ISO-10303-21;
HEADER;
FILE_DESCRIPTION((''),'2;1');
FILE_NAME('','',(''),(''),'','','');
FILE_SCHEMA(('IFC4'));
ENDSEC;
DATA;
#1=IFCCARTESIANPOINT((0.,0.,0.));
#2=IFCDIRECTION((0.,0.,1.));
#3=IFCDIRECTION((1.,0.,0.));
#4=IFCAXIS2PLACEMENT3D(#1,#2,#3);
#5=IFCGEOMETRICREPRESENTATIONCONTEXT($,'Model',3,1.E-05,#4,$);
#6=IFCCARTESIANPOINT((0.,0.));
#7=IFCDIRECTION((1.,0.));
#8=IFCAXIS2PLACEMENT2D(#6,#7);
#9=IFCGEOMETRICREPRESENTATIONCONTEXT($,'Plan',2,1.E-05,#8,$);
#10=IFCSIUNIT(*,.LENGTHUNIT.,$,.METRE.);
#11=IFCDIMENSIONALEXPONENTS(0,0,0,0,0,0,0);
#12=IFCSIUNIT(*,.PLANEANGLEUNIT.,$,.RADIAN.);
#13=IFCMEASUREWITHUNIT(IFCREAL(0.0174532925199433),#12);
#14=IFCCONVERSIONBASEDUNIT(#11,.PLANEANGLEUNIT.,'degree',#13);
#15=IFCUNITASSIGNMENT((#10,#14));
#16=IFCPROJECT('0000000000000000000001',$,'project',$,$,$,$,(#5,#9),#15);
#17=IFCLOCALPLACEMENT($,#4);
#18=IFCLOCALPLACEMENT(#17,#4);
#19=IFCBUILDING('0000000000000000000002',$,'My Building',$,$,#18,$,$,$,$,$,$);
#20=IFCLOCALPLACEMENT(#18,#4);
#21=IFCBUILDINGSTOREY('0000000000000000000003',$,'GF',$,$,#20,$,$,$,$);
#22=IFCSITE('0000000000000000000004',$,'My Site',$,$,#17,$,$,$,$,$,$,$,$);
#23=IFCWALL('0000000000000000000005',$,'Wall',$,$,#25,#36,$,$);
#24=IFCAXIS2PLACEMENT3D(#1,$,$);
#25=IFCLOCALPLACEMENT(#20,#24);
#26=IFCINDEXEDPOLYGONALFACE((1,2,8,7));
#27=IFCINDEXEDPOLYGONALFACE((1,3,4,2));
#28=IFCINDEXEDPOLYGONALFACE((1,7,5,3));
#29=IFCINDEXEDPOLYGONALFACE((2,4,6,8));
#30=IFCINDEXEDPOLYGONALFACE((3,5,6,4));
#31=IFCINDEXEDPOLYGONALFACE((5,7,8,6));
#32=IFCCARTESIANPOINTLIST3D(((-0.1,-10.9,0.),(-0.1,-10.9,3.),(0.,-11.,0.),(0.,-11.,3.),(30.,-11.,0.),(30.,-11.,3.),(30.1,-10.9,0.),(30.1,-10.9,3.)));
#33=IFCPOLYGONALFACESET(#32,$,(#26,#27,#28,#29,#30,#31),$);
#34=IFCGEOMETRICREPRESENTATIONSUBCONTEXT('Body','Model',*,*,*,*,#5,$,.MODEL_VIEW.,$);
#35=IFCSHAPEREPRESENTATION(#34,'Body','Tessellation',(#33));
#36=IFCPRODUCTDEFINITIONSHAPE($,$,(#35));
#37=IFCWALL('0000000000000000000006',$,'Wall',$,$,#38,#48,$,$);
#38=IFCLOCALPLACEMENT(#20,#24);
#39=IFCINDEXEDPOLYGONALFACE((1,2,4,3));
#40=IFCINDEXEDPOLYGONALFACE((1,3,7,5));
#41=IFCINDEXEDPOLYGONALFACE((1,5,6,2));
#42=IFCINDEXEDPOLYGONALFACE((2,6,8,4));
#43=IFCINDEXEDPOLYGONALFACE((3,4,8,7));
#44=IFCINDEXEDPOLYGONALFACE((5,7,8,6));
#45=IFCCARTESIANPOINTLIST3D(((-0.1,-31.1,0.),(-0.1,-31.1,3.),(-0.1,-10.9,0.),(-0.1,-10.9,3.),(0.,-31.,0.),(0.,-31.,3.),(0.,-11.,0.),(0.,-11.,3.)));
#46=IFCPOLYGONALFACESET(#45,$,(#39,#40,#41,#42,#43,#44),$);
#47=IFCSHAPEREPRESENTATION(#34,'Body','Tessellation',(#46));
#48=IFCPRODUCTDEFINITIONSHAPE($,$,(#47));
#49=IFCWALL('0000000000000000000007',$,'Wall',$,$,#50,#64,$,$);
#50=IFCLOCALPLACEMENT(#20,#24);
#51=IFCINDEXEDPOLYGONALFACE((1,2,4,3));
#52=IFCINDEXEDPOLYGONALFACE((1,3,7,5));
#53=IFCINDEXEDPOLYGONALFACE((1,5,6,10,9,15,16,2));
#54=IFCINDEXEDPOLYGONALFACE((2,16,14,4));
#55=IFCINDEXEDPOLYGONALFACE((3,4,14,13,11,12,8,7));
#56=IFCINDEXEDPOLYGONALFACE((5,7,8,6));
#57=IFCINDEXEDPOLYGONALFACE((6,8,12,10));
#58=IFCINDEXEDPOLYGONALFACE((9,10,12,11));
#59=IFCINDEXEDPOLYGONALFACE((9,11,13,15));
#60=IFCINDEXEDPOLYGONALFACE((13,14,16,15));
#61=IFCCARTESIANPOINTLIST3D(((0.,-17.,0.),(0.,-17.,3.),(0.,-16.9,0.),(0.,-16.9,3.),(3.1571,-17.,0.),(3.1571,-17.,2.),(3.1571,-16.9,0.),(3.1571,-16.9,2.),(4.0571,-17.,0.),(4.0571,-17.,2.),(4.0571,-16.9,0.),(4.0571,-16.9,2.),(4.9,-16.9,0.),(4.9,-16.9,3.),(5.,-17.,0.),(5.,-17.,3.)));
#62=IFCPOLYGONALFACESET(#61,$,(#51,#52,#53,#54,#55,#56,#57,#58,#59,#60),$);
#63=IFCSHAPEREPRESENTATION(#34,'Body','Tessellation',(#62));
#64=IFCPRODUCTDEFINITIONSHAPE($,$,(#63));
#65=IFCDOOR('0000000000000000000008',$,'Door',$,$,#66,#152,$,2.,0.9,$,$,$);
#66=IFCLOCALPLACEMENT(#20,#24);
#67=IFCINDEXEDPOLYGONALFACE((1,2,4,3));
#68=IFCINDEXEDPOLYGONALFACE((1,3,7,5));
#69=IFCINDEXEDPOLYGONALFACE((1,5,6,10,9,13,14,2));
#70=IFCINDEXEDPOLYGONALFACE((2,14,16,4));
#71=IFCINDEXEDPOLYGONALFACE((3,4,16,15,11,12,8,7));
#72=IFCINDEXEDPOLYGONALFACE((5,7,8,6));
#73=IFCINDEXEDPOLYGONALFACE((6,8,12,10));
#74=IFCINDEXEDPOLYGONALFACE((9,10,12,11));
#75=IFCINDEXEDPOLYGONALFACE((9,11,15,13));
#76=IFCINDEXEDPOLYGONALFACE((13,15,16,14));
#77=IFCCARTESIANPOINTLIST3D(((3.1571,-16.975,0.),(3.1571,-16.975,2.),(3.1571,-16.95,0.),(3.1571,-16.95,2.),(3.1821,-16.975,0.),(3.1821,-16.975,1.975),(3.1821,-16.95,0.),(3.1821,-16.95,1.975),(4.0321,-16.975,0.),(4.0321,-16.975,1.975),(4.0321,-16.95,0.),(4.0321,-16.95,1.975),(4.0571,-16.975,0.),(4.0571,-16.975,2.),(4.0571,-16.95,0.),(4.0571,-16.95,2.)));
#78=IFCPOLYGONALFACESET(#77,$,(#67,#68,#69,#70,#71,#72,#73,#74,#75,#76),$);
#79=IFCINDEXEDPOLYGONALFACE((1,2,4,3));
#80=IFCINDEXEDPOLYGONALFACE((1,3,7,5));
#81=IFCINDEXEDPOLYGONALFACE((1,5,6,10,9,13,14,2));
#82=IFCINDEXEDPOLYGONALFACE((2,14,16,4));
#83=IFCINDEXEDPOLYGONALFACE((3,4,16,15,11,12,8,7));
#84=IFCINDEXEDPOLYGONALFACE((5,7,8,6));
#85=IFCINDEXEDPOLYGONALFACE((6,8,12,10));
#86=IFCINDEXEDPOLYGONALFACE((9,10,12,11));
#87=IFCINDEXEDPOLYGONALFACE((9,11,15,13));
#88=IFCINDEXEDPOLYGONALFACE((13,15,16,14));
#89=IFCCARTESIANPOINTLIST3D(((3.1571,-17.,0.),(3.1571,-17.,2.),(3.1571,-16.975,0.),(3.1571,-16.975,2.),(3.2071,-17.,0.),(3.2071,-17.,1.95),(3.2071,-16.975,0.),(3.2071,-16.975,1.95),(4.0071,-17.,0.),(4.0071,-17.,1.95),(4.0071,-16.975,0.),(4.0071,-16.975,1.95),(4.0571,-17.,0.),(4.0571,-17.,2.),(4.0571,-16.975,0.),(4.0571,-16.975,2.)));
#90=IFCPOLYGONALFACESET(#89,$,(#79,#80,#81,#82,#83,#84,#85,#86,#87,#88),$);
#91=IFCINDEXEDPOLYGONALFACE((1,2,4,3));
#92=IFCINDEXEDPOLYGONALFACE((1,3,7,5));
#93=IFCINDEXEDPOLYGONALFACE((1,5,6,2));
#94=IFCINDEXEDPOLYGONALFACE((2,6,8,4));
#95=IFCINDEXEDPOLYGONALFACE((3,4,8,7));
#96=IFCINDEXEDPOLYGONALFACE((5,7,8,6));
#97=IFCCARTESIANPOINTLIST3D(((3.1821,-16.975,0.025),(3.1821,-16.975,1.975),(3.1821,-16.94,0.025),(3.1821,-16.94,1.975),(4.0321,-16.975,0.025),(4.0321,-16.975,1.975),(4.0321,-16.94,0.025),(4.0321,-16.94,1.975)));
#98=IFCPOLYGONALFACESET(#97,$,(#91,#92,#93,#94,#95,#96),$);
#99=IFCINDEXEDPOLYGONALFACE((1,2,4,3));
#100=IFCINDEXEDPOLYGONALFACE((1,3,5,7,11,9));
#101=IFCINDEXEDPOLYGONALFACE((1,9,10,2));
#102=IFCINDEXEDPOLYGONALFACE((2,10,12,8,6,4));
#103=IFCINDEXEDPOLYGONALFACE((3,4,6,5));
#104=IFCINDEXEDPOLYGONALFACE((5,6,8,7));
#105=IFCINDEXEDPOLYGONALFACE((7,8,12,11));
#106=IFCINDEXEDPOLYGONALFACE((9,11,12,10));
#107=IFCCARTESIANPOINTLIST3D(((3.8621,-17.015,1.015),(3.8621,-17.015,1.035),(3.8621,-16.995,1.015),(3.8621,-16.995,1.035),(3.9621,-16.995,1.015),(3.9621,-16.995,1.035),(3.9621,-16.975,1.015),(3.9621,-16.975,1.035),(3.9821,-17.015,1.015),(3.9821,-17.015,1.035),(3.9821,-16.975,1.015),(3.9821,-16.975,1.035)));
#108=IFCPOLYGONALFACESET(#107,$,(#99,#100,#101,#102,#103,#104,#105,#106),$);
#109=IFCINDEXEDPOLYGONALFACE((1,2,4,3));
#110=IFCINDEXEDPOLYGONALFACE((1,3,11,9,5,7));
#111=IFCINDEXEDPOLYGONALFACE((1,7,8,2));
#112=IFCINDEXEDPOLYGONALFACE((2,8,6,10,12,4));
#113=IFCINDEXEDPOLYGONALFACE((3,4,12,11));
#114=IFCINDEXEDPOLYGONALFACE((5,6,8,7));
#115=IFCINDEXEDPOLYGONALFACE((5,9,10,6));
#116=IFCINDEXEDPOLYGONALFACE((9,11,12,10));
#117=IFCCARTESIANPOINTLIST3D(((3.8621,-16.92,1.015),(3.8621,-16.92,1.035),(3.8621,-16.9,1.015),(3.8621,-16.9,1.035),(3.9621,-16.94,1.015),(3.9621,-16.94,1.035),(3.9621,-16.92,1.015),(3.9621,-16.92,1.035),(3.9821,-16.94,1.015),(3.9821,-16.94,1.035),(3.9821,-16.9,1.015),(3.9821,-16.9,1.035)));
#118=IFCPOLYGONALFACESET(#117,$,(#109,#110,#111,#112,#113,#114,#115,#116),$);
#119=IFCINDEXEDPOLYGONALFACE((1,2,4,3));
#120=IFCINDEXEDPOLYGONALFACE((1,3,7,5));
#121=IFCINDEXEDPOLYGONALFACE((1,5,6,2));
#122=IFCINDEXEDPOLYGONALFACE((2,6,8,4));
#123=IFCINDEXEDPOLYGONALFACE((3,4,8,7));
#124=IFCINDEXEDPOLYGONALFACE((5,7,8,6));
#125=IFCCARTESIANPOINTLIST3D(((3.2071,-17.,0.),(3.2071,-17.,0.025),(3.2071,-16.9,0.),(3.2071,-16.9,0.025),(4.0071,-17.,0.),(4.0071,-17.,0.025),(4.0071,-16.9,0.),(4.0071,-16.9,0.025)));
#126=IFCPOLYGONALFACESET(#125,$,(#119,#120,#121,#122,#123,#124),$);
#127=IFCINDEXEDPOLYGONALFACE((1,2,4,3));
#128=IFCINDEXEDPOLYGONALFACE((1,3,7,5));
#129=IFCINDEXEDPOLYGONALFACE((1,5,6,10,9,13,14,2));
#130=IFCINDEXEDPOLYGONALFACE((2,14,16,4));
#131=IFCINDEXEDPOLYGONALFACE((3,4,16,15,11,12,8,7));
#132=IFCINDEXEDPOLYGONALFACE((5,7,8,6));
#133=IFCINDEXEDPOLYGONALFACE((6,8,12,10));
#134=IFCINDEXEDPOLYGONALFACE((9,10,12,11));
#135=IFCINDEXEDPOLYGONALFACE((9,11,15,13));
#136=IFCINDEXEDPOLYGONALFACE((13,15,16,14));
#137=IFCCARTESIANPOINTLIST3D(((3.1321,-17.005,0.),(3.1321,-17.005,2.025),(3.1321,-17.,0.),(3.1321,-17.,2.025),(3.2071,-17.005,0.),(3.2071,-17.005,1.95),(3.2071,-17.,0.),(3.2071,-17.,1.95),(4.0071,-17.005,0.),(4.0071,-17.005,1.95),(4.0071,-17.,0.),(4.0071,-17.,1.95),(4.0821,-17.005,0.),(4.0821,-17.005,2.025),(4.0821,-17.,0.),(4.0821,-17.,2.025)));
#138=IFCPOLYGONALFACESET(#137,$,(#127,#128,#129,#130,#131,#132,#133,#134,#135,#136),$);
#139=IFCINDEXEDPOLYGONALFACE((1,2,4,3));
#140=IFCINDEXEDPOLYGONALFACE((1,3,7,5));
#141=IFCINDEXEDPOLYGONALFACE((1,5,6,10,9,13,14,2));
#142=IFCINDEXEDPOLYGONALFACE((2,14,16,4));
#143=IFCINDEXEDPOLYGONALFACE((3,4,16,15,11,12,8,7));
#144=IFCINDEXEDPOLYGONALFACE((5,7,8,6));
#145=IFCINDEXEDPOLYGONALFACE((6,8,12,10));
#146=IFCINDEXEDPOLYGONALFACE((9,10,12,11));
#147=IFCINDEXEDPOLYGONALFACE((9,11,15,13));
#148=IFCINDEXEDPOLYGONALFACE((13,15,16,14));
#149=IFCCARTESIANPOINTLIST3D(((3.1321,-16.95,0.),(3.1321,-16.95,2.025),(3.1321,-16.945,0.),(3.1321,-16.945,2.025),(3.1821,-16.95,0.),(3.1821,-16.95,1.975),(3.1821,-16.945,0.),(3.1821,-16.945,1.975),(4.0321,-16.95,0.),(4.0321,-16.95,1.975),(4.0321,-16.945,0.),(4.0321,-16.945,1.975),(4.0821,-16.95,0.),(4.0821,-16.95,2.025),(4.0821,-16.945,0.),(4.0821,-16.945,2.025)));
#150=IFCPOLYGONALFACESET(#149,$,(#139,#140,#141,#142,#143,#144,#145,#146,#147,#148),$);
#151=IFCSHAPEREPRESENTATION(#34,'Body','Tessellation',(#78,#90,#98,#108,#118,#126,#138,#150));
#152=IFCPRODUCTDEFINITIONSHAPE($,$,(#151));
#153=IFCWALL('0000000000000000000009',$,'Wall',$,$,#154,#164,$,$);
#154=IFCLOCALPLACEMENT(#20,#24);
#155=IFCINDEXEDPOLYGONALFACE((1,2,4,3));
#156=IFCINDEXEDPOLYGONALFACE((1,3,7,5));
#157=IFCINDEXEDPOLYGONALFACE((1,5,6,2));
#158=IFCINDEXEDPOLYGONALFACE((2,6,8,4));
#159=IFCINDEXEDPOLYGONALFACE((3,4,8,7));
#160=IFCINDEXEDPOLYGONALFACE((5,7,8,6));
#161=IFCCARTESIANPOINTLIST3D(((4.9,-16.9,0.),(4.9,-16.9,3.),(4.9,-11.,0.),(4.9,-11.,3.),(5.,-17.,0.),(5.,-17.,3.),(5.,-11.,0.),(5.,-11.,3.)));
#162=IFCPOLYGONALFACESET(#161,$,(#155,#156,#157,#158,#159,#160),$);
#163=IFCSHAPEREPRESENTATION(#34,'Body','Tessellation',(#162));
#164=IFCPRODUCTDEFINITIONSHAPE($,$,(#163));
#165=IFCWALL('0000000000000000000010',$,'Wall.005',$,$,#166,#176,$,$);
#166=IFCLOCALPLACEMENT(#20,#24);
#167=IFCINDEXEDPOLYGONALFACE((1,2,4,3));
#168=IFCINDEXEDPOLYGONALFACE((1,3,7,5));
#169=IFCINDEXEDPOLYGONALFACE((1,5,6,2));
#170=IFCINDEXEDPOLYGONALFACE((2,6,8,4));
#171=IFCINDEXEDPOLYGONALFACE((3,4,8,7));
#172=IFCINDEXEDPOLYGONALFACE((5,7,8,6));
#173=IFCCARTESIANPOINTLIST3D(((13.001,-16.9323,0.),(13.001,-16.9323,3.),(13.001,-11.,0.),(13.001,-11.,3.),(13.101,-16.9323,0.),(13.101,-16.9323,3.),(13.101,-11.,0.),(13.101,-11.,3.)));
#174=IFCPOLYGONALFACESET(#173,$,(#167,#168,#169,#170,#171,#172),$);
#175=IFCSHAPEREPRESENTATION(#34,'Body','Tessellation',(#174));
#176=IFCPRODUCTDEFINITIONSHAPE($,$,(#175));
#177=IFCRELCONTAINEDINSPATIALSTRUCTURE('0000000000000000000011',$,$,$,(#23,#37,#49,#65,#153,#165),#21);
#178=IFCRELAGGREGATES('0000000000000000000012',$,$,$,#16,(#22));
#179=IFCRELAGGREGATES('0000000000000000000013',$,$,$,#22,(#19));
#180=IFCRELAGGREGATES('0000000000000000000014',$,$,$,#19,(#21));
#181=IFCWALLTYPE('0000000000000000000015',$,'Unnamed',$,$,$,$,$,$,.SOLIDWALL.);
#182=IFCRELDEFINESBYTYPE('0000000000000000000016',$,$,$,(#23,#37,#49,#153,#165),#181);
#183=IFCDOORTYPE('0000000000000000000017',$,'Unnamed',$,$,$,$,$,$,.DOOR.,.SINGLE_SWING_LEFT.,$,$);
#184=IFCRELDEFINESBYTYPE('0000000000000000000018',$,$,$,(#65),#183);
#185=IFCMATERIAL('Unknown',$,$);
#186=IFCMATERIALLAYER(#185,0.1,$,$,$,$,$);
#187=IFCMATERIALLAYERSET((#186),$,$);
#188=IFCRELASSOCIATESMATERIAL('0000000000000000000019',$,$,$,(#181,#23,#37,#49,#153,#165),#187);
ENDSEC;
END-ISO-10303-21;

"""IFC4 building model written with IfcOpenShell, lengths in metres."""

from ifc_helpers import new_model, entity, si_unit, converted_unit, frame, origin_with_axes, origin_2d_with_axis, place, context, subcontext, project, spatial, line, indexed_curve, outline, extrude, shape, source, transform, mapped, material, layer, layer_set, layer_usage, type_object, type_shapes, element, fill, save


model = new_model("IFC4")

# Units and contexts
model_context = context("Model", 3, precision=1e-05, world=origin_with_axes())
plan_context = context("Plan", 2, precision=1e-05, world=origin_2d_with_axis())
body_context_1 = subcontext(model_context, "Body", "Model", "MODEL_VIEW")
body_context_2 = subcontext(plan_context, "Body", "Plan", "PLAN_VIEW")
ifc_project = project(units=[si_unit("LENGTHUNIT", "METRE"), converted_unit("PLANEANGLEUNIT", "degree", entity("IfcReal", 0.0174532925199433), si_unit("PLANEANGLEUNIT", "RADIAN"), dimensions=[0, 0, 0, 0, 0, 0, 0])], contexts=[model_context, plan_context])

# Site, building, storey
site_placement = place(None, origin_with_axes())
site = spatial("IfcSite", under=ifc_project, at=site_placement, Name="My Site")
building_placement = place(site_placement, origin_with_axes())
building = spatial("IfcBuilding", under=site, at=building_placement, Name="My Building")
storey_placement = place(building_placement, origin_with_axes())
storey = spatial("IfcBuildingStorey", under=building, at=storey_placement, Name="GF")

# Walls
ifc_material = material(Name="Unknown")
ifc_layer = layer(ifc_material, 0.1)
ifc_layer_set = layer_set([ifc_layer])
ifc_layer_usage_1 = layer_usage(ifc_layer_set, "AXIS2", "POSITIVE", 0.0)
wall_type = type_object("IfcWallType", Name="Unnamed", PredefinedType="SOLIDWALL", material=ifc_layer_set)
wall_1_placement = place(storey_placement, frame((0.0, -11.0, 0.0), z_axis=(0.0, 0.0, 1.0), x_axis=(1.0, 0.0, 0.0)))
element("IfcWall", 1, at=wall_1_placement, inside=storey, type_object=wall_type, material=ifc_layer_usage_1, Name="Wall", context=body_context_1, shape_type="SweptSolid", body=[
    extrude(outline(indexed_curve([(0.0, 0.0), (-0.1, 0.1), (30.1, 0.1), (30.0, 0.0)], segments=[line(1, 2, 3, 4, 1)])), origin_with_axes(), (0.0, 0.0, 1.0), 3.0),
])
ifc_layer_usage_2 = layer_usage(ifc_layer_set, "AXIS2", "POSITIVE", 0.0)
wall_2_placement = place(storey_placement, frame((0.0, -31.0, 0.0), z_axis=(0.0, 0.0, 1.0), x_axis=(0.0, 1.0, 0.0)))
element("IfcWall", 2, at=wall_2_placement, inside=storey, type_object=wall_type, material=ifc_layer_usage_2, Name="Wall", context=body_context_1, shape_type="SweptSolid", body=[
    extrude(outline(indexed_curve([(0.0, 0.0), (-0.1, 0.1), (20.1, 0.1), (20.0, 0.0)], segments=[line(1, 2, 3, 4, 1)])), origin_with_axes(), (0.0, 0.0, 1.0), 3.0),
])

# Wall, opening, door
ifc_layer_usage_3 = layer_usage(ifc_layer_set, "AXIS2", "POSITIVE", 0.0)
wall_3_placement = place(storey_placement, frame((0.0, -17.0, 0.0), z_axis=(0.0, 0.0, 1.0), x_axis=(1.0, 0.0, 0.0)))
wall_3 = element("IfcWall", 3, at=wall_3_placement, inside=storey, type_object=wall_type, material=ifc_layer_usage_3, Name="Wall", context=body_context_1, shape_type="SweptSolid", body=[
    extrude(outline(indexed_curve([(0.0, 0.0), (0.0, 0.1), (4.9, 0.1), (5.0, 0.0)], segments=[line(1, 2, 3, 4, 1)])), origin_with_axes(), (0.0, 0.0, 1.0), 3.0),
])
shared_shape_1 = source(origin_with_axes(), body_context_1, "Body", "SweptSolid", [
    extrude(outline(indexed_curve([(0.0, 0.0), (0.9, 0.0), (0.9, 2.0), (0.0, 2.0)], segments=[line(1, 2, 3, 4, 1)])), frame((0.0, -0.6, 0.0), z_axis=(0.0, -1.0, 0.0), x_axis=(1.0, 0.0, 0.0)), (0.0, 0.0, -1.0), 1.2),
])
opening_1_placement = place(wall_3_placement, frame((3.1571, 0.0, 0.0), z_axis=(0.0, 0.0, 1.0), x_axis=(1.0, 0.0, 0.0)))
opening_1 = element("IfcOpeningElement", 4, at=opening_1_placement, cuts=wall_3, PredefinedType="OPENING", context=body_context_1, shape_type="MappedRepresentation", body=[
    mapped(shared_shape_1, transform((0.0, 0.0, 0.0), x_axis=(1.0, 0.0, 0.0), y_axis=(0.0, 1.0, 0.0), z_axis=(0.0, 0.0, 1.0), scale=1.0)),
])
door_type = type_object("IfcDoorType", Name="Unnamed", OperationType="SINGLE_SWING_LEFT", PredefinedType="DOOR")
shared_shape_2 = source(origin_with_axes(), body_context_1, "Body", "SweptSolid", [
    extrude(outline(indexed_curve([(0.0, 0.0), (0.0, 2.0), (0.9, 2.0), (0.9, 0.0), (0.875, 0.0), (0.875, 1.975), (0.025, 1.975), (0.025, 0.0)], segments=[line(1, 2, 3, 4, 5, 6, 7, 8, 1)])), frame((0.0, 0.025, 0.0), z_axis=(0.0, -1.0, 0.0), x_axis=(1.0, 0.0, 0.0)), (0.0, 0.0, -1.0), 0.025),
    extrude(outline(indexed_curve([(0.0, 0.0), (0.0, 2.0), (0.9, 2.0), (0.9, 0.0), (0.85, 0.0), (0.85, 1.95), (0.05, 1.95), (0.05, 0.0)], segments=[line(1, 2, 3, 4, 5, 6, 7, 8, 1)])), frame((0.0, 0.0, 0.0), z_axis=(0.0, -1.0, 0.0), x_axis=(1.0, 0.0, 0.0)), (0.0, 0.0, -1.0), 0.025),
    extrude(outline(indexed_curve([(0.0, 0.0), (0.85, 0.0), (0.85, 0.035), (0.0, 0.035)], segments=[line(1, 2, 3, 4, 1)])), frame((0.025, 0.025, 0.025), z_axis=(0.0, 0.0, 1.0), x_axis=(1.0, 0.0, 0.0)), (0.0, 0.0, 1.0), 1.95),
    extrude(outline(indexed_curve([(0.0, 0.0), (0.0, -0.04), (-0.12, -0.04), (-0.12, -0.02), (-0.02, -0.02), (-0.02, 0.0)], segments=[line(1, 2, 3, 4, 5, 6, 1)])), frame((0.825, 0.025, 1.015), z_axis=(0.0, 0.0, 1.0), x_axis=(1.0, 0.0, 0.0)), (0.0, 0.0, 1.0), 0.02),
    extrude(outline(indexed_curve([(0.0, 0.0), (0.0, 0.04), (-0.12, 0.04), (-0.12, 0.02), (-0.02, 0.02), (-0.02, 0.0)], segments=[line(1, 2, 3, 4, 5, 6, 1)])), frame((0.825, 0.06, 1.015), z_axis=(0.0, 0.0, 1.0), x_axis=(1.0, 0.0, 0.0)), (0.0, 0.0, 1.0), 0.02),
    extrude(outline(indexed_curve([(0.0, 0.0), (0.8, 0.0), (0.8, 0.1), (0.0, 0.1)], segments=[line(1, 2, 3, 4, 1)])), frame((0.05, 0.0, 0.0), z_axis=(0.0, 0.0, 1.0), x_axis=(1.0, 0.0, 0.0)), (0.0, 0.0, 1.0), 0.025),
    extrude(outline(indexed_curve([(0.0, 0.0), (0.0, 2.025), (0.95, 2.025), (0.95, 0.0), (0.875, 0.0), (0.875, 1.95), (0.075, 1.95), (0.075, 0.0)], segments=[line(1, 2, 3, 4, 5, 6, 7, 8, 1)])), frame((-0.025, -0.005, 0.0), z_axis=(0.0, -1.0, 0.0), x_axis=(1.0, 0.0, 0.0)), (0.0, 0.0, -1.0), 0.005),
    extrude(outline(indexed_curve([(0.0, 0.0), (0.0, 2.025), (0.95, 2.025), (0.95, 0.0), (0.9, 0.0), (0.9, 1.975), (0.05, 1.975), (0.05, 0.0)], segments=[line(1, 2, 3, 4, 5, 6, 7, 8, 1)])), frame((-0.025, 0.05, 0.0), z_axis=(0.0, -1.0, 0.0), x_axis=(1.0, 0.0, 0.0)), (0.0, 0.0, -1.0), 0.005),
])
shared_shape_3 = source(origin_with_axes(), body_context_2, "Body", "Curve2D", [
    entity("IfcIndexedPolyCurve", entity("IfcCartesianPointList2D", [[0.0, 0.0], [0.0, 0.05], [0.025, 0.05], [0.025, 0.025], [0.05, 0.025], [0.05, 0.0]]), [entity("IfcLineIndex", [1, 2, 3, 4, 5, 6, 1])]),
    entity("IfcIndexedPolyCurve", entity("IfcCartesianPointList2D", [[0.9, 0.0], [0.9, 0.05], [0.875, 0.05], [0.875, 0.025], [0.85, 0.025], [0.85, 0.0]]), [entity("IfcLineIndex", [1, 2, 3, 4, 5, 6, 1])]),
    entity("IfcTrimmedCurve", entity("IfcEllipse", entity("IfcAxis2Placement2D", entity("IfcCartesianPoint", [0.06, 0.05]), entity("IfcDirection", [1.0, 0.0])), 0.815, 0.85), [entity("IfcCartesianPoint", [0.875, 0.05])], [entity("IfcCartesianPoint", [0.06, 0.9])], True, "CARTESIAN"),
    entity("IfcIndexedPolyCurve", entity("IfcCartesianPointList2D", [[0.025, 0.05], [0.06, 0.05], [0.06, 0.9], [0.025, 0.9]]), [entity("IfcLineIndex", [1, 2, 3, 4, 1])]),
])
type_shapes(door_type, [shared_shape_2, shared_shape_3])
door_1_placement = place(opening_1_placement, origin_with_axes())
door_1 = element("IfcDoor", 5, at=door_1_placement, inside=storey, type_object=door_type, Name="Door", OverallHeight=2.0, OverallWidth=0.9, shapes=[
    shape(body_context_1, "Body", "MappedRepresentation", [mapped(shared_shape_2, transform((0.0, 0.0, 0.0), x_axis=(1.0, 0.0, 0.0), y_axis=(0.0, 1.0, 0.0), z_axis=(0.0, 0.0, 1.0), scale=1.0))]),
    shape(body_context_2, "Body", "MappedRepresentation", [mapped(shared_shape_3, transform((0.0, 0.0, 0.0), x_axis=(1.0, 0.0, 0.0), y_axis=(0.0, 1.0, 0.0), z_axis=(0.0, 0.0, 1.0), scale=1.0))]),
])
fill(opening_1, door_1)

# Wall
ifc_layer_usage_4 = layer_usage(ifc_layer_set, "AXIS2", "POSITIVE", 0.0)
wall_4_placement = place(storey_placement, frame((5.0, -17.0, 0.0), z_axis=(0.0, 0.0, 1.0), x_axis=(0.0, 1.0, 0.0)))
element("IfcWall", 6, at=wall_4_placement, inside=storey, type_object=wall_type, material=ifc_layer_usage_4, Name="Wall", context=body_context_1, shape_type="SweptSolid", body=[
    extrude(outline(indexed_curve([(0.0, 0.0), (0.1, 0.1), (6.0, 0.1), (6.0, 0.0)], segments=[line(1, 2, 3, 4, 1)])), origin_with_axes(), (0.0, 0.0, 1.0), 3.0),
])

# Wall
ifc_layer_usage_5 = layer_usage(ifc_layer_set, "AXIS2", "POSITIVE", 0.0)
wall_5_placement = place(storey_placement, frame((13.101, -16.9323, 0.0), z_axis=(0.0, 0.0, 1.0), x_axis=(0.0, 1.0, 0.0)))
element("IfcWall", 7, at=wall_5_placement, inside=storey, type_object=wall_type, material=ifc_layer_usage_5, Name="Wall.005", context=body_context_1, shape_type="SweptSolid", body=[
    extrude(outline(indexed_curve([(0.0, 0.0), (0.0, 0.1), (5.9323, 0.1), (5.9323, 0.0)], segments=[line(1, 2, 3, 4, 1)])), origin_with_axes(), (0.0, 0.0, 1.0), 3.0),
])

save(model, "model.ifc")
